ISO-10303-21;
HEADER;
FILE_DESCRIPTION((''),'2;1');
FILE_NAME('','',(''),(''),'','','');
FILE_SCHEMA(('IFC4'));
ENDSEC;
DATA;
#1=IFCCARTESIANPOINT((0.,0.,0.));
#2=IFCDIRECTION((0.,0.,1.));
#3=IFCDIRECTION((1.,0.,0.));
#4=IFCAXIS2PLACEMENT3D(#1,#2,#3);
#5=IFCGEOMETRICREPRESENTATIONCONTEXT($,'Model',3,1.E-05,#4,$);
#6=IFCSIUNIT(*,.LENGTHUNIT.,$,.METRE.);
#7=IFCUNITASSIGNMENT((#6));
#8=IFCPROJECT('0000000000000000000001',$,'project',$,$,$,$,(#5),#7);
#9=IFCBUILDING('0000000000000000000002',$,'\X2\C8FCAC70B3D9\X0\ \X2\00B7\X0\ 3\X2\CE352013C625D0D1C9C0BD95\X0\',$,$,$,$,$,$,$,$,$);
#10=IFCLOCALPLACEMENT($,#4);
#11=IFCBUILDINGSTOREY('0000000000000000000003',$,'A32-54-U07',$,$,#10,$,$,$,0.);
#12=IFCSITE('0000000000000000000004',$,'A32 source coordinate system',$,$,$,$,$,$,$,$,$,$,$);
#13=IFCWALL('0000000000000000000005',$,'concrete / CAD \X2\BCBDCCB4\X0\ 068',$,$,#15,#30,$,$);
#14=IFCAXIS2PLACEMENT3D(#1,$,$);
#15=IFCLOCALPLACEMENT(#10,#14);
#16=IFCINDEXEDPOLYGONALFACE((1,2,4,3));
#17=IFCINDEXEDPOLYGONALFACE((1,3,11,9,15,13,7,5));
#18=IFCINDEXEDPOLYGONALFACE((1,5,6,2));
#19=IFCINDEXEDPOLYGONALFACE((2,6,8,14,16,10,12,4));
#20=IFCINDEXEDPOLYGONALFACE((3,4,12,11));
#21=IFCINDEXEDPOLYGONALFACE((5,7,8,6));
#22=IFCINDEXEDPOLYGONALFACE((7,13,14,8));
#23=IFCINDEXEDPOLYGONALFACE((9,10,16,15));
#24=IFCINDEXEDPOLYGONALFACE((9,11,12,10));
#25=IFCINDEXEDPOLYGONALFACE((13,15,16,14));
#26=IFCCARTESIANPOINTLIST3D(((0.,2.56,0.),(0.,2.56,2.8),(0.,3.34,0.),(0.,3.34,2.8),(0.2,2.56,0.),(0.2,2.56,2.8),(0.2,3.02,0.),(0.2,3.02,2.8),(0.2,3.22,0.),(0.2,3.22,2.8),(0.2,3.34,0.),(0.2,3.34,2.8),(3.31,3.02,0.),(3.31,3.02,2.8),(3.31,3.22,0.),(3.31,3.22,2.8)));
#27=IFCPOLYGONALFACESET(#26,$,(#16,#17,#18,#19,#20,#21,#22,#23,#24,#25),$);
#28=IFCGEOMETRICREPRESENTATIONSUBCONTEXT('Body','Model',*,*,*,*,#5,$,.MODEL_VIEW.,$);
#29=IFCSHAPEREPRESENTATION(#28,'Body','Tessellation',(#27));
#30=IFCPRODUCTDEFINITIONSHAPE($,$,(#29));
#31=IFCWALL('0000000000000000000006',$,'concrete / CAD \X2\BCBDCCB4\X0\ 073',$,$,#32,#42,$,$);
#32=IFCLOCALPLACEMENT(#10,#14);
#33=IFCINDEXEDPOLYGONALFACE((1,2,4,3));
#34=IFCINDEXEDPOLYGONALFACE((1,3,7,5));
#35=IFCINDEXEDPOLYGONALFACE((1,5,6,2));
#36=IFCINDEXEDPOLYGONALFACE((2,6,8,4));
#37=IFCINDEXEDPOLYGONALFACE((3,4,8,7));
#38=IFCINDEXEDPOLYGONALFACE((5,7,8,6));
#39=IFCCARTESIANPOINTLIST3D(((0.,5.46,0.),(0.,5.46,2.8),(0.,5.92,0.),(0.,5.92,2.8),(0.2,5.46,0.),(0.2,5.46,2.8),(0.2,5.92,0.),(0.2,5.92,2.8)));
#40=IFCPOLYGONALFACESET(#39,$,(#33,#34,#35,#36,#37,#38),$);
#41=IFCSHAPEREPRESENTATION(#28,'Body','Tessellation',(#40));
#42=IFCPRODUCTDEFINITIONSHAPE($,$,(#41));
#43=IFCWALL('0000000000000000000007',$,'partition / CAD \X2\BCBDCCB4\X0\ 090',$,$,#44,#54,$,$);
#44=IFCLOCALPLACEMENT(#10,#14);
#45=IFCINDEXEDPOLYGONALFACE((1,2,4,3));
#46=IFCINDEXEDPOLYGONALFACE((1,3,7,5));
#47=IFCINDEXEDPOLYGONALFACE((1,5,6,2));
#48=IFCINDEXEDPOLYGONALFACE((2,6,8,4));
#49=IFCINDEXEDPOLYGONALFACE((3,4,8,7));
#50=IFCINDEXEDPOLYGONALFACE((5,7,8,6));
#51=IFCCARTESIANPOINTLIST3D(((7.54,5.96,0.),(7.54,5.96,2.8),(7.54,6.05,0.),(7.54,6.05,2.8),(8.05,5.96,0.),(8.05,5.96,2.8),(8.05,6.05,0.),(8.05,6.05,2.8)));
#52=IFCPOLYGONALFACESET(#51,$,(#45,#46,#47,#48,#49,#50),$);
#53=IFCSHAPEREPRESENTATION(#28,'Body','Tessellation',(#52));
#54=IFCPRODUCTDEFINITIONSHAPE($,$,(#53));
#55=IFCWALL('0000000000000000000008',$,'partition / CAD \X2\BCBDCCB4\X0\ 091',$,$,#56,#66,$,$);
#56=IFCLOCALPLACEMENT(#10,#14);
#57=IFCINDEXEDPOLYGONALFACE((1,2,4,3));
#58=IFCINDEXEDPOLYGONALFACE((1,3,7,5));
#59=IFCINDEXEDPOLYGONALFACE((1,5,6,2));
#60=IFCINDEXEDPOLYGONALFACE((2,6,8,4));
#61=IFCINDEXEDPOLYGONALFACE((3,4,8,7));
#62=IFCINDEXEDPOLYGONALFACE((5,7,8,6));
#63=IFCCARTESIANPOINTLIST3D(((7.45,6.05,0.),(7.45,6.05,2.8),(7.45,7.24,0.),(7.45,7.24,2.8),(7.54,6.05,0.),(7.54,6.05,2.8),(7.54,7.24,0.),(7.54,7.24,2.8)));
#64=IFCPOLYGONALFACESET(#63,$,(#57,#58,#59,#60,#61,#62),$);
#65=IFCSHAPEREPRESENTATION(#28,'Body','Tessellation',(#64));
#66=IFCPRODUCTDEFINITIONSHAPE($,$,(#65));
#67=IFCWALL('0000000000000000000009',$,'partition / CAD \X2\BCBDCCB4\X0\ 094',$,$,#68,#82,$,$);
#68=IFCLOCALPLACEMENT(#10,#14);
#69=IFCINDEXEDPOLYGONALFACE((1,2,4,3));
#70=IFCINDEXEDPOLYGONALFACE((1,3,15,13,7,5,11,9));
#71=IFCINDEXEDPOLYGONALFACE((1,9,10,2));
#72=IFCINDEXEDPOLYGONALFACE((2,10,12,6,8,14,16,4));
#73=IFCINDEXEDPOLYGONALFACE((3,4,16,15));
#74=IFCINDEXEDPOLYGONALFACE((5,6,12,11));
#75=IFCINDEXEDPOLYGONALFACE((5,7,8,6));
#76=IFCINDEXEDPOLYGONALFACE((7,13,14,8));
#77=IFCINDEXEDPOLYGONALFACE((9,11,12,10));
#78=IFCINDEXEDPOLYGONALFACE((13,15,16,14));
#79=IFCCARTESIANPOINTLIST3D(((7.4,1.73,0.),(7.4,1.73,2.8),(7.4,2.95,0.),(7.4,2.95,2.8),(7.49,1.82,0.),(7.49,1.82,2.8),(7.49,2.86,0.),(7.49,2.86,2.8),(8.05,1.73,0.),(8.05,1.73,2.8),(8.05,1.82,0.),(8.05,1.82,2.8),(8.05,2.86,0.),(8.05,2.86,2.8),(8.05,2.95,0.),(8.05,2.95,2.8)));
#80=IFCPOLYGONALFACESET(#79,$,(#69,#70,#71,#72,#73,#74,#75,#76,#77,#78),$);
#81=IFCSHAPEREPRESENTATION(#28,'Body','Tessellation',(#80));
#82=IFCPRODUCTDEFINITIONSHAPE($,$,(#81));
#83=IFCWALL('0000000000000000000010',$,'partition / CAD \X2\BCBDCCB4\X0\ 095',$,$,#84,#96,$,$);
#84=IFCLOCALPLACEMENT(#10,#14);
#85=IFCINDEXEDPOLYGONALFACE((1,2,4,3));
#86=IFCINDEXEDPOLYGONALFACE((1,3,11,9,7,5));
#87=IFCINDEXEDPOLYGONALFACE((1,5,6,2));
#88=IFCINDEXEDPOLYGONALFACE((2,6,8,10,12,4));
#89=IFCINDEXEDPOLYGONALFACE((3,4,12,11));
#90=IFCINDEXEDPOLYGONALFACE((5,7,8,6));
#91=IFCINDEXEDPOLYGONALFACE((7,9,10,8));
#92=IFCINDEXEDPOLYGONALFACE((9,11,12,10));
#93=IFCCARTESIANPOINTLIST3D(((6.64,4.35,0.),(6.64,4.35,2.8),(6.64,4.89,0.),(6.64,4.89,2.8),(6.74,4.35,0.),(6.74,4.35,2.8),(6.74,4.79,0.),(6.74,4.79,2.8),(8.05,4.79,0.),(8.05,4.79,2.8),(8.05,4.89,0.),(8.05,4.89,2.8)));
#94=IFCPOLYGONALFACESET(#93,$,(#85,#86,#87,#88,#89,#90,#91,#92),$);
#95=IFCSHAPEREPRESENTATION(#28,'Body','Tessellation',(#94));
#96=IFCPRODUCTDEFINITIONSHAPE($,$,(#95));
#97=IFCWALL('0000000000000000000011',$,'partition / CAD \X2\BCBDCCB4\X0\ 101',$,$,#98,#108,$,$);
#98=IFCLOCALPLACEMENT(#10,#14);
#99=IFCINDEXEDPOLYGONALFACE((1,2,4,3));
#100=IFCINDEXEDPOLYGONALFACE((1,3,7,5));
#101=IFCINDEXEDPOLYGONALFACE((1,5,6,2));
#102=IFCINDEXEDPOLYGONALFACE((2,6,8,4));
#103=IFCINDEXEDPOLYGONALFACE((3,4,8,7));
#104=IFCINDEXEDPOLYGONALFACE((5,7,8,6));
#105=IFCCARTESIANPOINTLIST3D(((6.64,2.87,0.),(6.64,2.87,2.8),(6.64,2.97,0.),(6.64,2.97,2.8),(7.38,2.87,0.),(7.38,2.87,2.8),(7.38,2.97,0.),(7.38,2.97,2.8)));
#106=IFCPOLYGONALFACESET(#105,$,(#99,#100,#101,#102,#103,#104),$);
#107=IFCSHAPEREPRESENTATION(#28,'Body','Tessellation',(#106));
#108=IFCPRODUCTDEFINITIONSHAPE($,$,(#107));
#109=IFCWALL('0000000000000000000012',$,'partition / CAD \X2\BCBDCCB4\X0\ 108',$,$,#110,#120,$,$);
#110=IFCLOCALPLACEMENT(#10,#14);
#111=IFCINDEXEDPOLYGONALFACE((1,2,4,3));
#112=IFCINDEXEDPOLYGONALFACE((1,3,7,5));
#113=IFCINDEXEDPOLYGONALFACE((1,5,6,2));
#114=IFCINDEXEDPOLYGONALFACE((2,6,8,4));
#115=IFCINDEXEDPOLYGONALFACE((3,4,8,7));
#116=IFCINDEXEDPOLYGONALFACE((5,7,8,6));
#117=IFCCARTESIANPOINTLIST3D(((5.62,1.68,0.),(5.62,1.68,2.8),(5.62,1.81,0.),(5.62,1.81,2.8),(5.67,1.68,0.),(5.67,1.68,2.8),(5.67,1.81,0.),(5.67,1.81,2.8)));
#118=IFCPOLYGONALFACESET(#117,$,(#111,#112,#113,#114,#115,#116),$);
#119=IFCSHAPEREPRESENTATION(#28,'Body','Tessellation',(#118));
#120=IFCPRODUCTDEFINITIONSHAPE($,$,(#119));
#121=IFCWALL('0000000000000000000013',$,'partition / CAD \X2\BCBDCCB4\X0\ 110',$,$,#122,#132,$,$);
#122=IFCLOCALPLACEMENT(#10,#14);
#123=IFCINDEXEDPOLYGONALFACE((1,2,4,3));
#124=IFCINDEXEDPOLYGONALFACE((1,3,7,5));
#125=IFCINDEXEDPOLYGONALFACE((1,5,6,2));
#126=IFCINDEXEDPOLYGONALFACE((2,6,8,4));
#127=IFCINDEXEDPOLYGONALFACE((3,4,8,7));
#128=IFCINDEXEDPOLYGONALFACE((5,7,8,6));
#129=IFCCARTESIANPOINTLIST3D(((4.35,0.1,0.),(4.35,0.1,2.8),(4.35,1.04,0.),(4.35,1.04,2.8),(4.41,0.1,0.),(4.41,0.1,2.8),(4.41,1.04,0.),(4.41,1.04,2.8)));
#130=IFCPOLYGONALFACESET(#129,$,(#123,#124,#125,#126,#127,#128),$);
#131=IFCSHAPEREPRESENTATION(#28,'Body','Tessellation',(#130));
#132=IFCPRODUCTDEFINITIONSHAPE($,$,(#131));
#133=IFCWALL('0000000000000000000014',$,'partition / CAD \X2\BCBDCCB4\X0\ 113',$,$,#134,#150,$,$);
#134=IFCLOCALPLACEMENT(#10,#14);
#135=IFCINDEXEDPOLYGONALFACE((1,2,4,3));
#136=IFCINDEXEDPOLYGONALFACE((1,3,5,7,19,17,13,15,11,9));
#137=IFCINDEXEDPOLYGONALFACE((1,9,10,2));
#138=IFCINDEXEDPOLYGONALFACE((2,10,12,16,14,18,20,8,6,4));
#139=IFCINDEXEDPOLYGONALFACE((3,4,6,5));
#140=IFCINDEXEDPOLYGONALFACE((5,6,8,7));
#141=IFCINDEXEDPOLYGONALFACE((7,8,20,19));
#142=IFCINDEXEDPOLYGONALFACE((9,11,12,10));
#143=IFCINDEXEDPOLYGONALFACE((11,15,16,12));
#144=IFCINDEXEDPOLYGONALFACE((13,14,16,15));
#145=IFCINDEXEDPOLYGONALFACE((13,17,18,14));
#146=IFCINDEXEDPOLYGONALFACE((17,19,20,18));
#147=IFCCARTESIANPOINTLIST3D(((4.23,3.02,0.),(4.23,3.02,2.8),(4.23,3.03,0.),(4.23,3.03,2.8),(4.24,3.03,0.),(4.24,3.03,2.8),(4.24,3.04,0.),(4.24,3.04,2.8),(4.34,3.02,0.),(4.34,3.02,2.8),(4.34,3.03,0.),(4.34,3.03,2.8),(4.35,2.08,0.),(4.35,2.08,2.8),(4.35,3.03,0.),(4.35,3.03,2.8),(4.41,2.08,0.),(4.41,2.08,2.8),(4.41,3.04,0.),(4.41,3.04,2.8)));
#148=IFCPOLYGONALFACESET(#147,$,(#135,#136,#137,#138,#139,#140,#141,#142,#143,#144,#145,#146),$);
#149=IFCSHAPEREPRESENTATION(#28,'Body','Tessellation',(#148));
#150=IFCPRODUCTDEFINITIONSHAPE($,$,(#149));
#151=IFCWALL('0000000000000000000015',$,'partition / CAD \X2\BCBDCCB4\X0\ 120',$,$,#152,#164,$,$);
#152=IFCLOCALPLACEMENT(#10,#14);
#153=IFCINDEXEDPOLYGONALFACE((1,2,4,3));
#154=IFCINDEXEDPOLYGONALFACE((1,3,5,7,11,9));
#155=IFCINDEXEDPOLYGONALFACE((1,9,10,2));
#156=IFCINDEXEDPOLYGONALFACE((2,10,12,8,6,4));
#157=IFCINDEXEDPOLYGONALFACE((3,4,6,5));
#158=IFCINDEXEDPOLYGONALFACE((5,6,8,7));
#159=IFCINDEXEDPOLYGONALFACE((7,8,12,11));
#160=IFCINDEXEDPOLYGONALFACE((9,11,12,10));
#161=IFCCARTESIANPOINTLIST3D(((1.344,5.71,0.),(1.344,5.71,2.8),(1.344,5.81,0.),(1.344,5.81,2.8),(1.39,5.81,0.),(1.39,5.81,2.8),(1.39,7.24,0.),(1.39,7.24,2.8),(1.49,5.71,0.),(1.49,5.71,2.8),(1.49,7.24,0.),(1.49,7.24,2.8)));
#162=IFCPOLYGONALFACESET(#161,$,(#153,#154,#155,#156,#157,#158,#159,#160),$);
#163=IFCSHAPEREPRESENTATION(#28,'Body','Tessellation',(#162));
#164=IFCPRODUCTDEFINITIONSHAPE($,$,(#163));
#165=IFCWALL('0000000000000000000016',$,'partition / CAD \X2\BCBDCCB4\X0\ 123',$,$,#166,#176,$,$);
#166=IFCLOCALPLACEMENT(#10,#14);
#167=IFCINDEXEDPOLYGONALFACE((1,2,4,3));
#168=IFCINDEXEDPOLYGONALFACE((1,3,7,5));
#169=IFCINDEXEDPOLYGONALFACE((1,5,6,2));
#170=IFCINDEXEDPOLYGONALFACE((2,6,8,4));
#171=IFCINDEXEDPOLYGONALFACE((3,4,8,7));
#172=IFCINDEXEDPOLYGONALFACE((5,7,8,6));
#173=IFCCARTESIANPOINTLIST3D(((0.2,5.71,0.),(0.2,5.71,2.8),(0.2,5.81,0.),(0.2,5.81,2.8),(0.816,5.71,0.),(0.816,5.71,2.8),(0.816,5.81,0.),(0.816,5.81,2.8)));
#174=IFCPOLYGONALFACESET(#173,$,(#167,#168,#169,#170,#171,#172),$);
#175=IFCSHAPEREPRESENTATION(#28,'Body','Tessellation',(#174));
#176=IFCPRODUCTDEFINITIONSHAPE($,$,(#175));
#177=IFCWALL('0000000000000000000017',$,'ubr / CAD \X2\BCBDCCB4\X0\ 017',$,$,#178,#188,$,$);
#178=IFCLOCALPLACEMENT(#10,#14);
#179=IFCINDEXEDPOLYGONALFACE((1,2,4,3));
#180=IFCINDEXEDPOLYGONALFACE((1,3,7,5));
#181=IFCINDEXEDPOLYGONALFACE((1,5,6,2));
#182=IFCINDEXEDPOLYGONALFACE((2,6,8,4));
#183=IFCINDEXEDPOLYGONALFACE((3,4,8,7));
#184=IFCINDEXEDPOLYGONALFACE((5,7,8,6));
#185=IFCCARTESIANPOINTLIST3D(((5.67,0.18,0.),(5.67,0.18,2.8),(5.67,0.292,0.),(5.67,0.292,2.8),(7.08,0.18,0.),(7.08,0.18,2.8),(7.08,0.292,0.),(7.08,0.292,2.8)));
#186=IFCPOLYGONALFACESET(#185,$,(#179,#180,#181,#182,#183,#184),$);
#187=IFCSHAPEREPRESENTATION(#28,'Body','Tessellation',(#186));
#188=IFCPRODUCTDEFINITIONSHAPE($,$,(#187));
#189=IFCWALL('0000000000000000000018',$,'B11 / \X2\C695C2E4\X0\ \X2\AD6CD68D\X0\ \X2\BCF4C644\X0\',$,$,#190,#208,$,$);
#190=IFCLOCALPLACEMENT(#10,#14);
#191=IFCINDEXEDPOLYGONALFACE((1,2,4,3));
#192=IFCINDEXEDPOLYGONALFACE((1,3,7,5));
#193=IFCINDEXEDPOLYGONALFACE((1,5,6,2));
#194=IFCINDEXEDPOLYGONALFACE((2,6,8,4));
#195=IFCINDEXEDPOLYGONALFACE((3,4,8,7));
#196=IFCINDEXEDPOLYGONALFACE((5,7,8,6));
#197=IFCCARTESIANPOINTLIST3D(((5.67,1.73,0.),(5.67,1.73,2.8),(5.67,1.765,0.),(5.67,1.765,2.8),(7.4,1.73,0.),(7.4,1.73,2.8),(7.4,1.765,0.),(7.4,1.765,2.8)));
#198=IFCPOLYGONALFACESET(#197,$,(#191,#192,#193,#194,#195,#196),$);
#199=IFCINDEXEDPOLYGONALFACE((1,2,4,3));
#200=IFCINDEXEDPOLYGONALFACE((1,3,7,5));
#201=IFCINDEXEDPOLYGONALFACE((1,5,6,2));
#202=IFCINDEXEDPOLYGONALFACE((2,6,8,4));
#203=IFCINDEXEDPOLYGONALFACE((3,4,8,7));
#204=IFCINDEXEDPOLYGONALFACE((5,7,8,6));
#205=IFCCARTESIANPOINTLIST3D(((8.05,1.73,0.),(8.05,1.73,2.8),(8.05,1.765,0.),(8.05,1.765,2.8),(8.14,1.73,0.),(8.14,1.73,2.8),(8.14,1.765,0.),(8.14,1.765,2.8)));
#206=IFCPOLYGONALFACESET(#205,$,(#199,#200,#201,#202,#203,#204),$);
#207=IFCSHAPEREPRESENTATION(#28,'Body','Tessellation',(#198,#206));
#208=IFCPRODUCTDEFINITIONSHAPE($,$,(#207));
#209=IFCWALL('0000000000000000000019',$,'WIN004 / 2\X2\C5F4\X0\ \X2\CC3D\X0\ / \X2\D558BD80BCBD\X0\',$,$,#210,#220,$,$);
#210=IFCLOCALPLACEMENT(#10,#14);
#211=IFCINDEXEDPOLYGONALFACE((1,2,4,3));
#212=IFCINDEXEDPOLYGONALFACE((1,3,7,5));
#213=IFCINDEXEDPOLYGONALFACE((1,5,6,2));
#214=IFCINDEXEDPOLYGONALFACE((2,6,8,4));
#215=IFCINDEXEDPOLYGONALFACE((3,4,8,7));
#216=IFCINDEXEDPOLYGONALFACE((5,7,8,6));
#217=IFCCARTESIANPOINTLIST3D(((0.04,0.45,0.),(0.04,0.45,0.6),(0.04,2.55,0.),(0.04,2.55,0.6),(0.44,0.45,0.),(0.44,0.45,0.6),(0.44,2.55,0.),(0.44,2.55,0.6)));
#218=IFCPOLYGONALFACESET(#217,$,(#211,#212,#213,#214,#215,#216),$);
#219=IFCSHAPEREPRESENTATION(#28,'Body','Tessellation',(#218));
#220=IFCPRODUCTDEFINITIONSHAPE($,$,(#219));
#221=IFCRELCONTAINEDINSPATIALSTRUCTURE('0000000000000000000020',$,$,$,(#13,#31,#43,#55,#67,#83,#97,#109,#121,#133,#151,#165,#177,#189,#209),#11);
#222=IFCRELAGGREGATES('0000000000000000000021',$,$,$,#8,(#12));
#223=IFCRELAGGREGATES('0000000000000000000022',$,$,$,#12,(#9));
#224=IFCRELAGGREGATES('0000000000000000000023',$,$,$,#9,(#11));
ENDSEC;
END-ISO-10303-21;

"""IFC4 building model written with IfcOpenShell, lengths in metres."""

from ifc_helpers import new_model, si_unit, origin, origin_with_axes, place, context, subcontext, project, spatial, polyline, outline, extrude, element, save


model = new_model("IFC4")

# Units and contexts
model_context = context("Model", 3, precision=1e-05, world=origin_with_axes())
body_context = subcontext(model_context, "Body", "Model", "MODEL_VIEW")
ifc_project = project(units=[si_unit("LENGTHUNIT", "METRE")], contexts=[model_context])

# Site, building, storey
site = spatial("IfcSite", under=ifc_project, Name="A32 source coordinate system")
building = spatial("IfcBuilding", under=site, Name="주거동 · 3층–옥탑지붕")
storey_placement = place(None, origin_with_axes())
storey = spatial("IfcBuildingStorey", under=building, at=storey_placement, Name="A32-54-U07", Elevation=0.0)

# Walls
wall_1_placement = place(storey_placement, origin_with_axes())
element("IfcWall", 1, at=wall_1_placement, inside=storey, Name="concrete / CAD 벽체 068", context=body_context, shape_type="SweptSolid", body=[
    extrude(outline(polyline([(0.2, 3.02), (0.2, 2.56), (0.0, 2.56), (0.0, 3.34), (0.2, 3.34), (0.2, 3.22), (3.31, 3.22), (3.31, 3.02), (0.2, 3.02)])), origin(), (0.0, 0.0, 1.0), 2.8),
])
wall_2_placement = place(storey_placement, origin_with_axes())
element("IfcWall", 2, at=wall_2_placement, inside=storey, Name="concrete / CAD 벽체 073", context=body_context, shape_type="SweptSolid", body=[
    extrude(outline(polyline([(0.2, 5.92), (0.2, 5.46), (0.0, 5.46), (0.0, 5.92), (0.2, 5.92)])), origin(), (0.0, 0.0, 1.0), 2.8),
])
wall_3_placement = place(storey_placement, origin_with_axes())
element("IfcWall", 3, at=wall_3_placement, inside=storey, Name="partition / CAD 벽체 090", context=body_context, shape_type="SweptSolid", body=[
    extrude(outline(polyline([(7.54, 5.96), (7.54, 6.05), (8.05, 6.05), (8.05, 5.96), (7.54, 5.96)])), origin(), (0.0, 0.0, 1.0), 2.8),
])
wall_4_placement = place(storey_placement, origin_with_axes())
element("IfcWall", 4, at=wall_4_placement, inside=storey, Name="partition / CAD 벽체 091", context=body_context, shape_type="SweptSolid", body=[
    extrude(outline(polyline([(7.54, 6.05), (7.45, 6.05), (7.45, 7.24), (7.54, 7.24), (7.54, 6.05)])), origin(), (0.0, 0.0, 1.0), 2.8),
])
wall_5_placement = place(storey_placement, origin_with_axes())
element("IfcWall", 5, at=wall_5_placement, inside=storey, Name="partition / CAD 벽체 094", context=body_context, shape_type="SweptSolid", body=[
    extrude(outline(polyline([(8.05, 1.73), (7.4, 1.73), (7.4, 2.95), (8.05, 2.95), (8.05, 2.86), (7.49, 2.86), (7.49, 1.82), (8.05, 1.82), (8.05, 1.73)])), origin(), (0.0, 0.0, 1.0), 2.8),
])
wall_6_placement = place(storey_placement, origin_with_axes())
element("IfcWall", 6, at=wall_6_placement, inside=storey, Name="partition / CAD 벽체 095", context=body_context, shape_type="SweptSolid", body=[
    extrude(outline(polyline([(6.64, 4.89), (8.05, 4.89), (8.05, 4.79), (6.74, 4.79), (6.74, 4.35), (6.64, 4.35), (6.64, 4.89)])), origin(), (0.0, 0.0, 1.0), 2.8),
])
wall_7_placement = place(storey_placement, origin_with_axes())
element("IfcWall", 7, at=wall_7_placement, inside=storey, Name="partition / CAD 벽체 101", context=body_context, shape_type="SweptSolid", body=[
    extrude(outline(polyline([(7.38, 2.97), (7.38, 2.87), (6.64, 2.87), (6.64, 2.97), (7.38, 2.97)])), origin(), (0.0, 0.0, 1.0), 2.8),
])
wall_8_placement = place(storey_placement, origin_with_axes())
element("IfcWall", 8, at=wall_8_placement, inside=storey, Name="partition / CAD 벽체 108", context=body_context, shape_type="SweptSolid", body=[
    extrude(outline(polyline([(5.67, 1.68), (5.62, 1.68), (5.62, 1.81), (5.67, 1.81), (5.67, 1.68)])), origin(), (0.0, 0.0, 1.0), 2.8),
])
wall_9_placement = place(storey_placement, origin_with_axes())
element("IfcWall", 9, at=wall_9_placement, inside=storey, Name="partition / CAD 벽체 110", context=body_context, shape_type="SweptSolid", body=[
    extrude(outline(polyline([(4.35, 1.04), (4.41, 1.04), (4.41, 0.1), (4.35, 0.1), (4.35, 1.04)])), origin(), (0.0, 0.0, 1.0), 2.8),
])
wall_10_placement = place(storey_placement, origin_with_axes())
element("IfcWall", 10, at=wall_10_placement, inside=storey, Name="partition / CAD 벽체 113", context=body_context, shape_type="SweptSolid", body=[
    extrude(outline(polyline([(4.24, 3.04), (4.41, 3.04), (4.41, 2.08), (4.35, 2.08), (4.35, 3.03), (4.34, 3.03), (4.34, 3.02), (4.23, 3.02), (4.23, 3.03), (4.24, 3.03), (4.24, 3.04)])), origin(), (0.0, 0.0, 1.0), 2.8),
])
wall_11_placement = place(storey_placement, origin_with_axes())
element("IfcWall", 11, at=wall_11_placement, inside=storey, Name="partition / CAD 벽체 120", context=body_context, shape_type="SweptSolid", body=[
    extrude(outline(polyline([(1.39, 7.24), (1.49, 7.24), (1.49, 5.71), (1.344, 5.71), (1.344, 5.81), (1.39, 5.81), (1.39, 7.24)])), origin(), (0.0, 0.0, 1.0), 2.8),
])
wall_12_placement = place(storey_placement, origin_with_axes())
element("IfcWall", 12, at=wall_12_placement, inside=storey, Name="partition / CAD 벽체 123", context=body_context, shape_type="SweptSolid", body=[
    extrude(outline(polyline([(0.816, 5.81), (0.816, 5.71), (0.2, 5.71), (0.2, 5.81), (0.816, 5.81)])), origin(), (0.0, 0.0, 1.0), 2.8),
])
wall_13_placement = place(storey_placement, origin_with_axes())
element("IfcWall", 13, at=wall_13_placement, inside=storey, Name="ubr / CAD 벽체 017", context=body_context, shape_type="SweptSolid", body=[
    extrude(outline(polyline([(7.08, 0.292), (7.08, 0.18), (5.67, 0.18), (5.67, 0.292), (7.08, 0.292)])), origin(), (0.0, 0.0, 1.0), 2.8),
])
wall_14_placement = place(storey_placement, origin_with_axes())
element("IfcWall", 14, at=wall_14_placement, inside=storey, Name="B11 / 욕실 구획 보완", context=body_context, shape_type="SweptSolid", body=[
    extrude(outline(polyline([(7.4, 1.765), (7.4, 1.73), (5.67, 1.73), (5.67, 1.765), (7.4, 1.765)])), origin(), (0.0, 0.0, 1.0), 2.8),
    extrude(outline(polyline([(8.05, 1.73), (8.05, 1.765), (8.14, 1.765), (8.14, 1.73), (8.05, 1.73)])), origin(), (0.0, 0.0, 1.0), 2.8),
])
wall_15_placement = place(storey_placement, origin_with_axes())
element("IfcWall", 15, at=wall_15_placement, inside=storey, Name="WIN004 / 2열 창 / 하부벽", context=body_context, shape_type="SweptSolid", body=[
    extrude(outline(polyline([(0.44, 0.45), (0.04, 0.45), (0.04, 2.55), (0.44, 2.55), (0.44, 0.45)])), origin(), (0.0, 0.0, 1.0), 0.6),
])

save(model, "model.ifc")
